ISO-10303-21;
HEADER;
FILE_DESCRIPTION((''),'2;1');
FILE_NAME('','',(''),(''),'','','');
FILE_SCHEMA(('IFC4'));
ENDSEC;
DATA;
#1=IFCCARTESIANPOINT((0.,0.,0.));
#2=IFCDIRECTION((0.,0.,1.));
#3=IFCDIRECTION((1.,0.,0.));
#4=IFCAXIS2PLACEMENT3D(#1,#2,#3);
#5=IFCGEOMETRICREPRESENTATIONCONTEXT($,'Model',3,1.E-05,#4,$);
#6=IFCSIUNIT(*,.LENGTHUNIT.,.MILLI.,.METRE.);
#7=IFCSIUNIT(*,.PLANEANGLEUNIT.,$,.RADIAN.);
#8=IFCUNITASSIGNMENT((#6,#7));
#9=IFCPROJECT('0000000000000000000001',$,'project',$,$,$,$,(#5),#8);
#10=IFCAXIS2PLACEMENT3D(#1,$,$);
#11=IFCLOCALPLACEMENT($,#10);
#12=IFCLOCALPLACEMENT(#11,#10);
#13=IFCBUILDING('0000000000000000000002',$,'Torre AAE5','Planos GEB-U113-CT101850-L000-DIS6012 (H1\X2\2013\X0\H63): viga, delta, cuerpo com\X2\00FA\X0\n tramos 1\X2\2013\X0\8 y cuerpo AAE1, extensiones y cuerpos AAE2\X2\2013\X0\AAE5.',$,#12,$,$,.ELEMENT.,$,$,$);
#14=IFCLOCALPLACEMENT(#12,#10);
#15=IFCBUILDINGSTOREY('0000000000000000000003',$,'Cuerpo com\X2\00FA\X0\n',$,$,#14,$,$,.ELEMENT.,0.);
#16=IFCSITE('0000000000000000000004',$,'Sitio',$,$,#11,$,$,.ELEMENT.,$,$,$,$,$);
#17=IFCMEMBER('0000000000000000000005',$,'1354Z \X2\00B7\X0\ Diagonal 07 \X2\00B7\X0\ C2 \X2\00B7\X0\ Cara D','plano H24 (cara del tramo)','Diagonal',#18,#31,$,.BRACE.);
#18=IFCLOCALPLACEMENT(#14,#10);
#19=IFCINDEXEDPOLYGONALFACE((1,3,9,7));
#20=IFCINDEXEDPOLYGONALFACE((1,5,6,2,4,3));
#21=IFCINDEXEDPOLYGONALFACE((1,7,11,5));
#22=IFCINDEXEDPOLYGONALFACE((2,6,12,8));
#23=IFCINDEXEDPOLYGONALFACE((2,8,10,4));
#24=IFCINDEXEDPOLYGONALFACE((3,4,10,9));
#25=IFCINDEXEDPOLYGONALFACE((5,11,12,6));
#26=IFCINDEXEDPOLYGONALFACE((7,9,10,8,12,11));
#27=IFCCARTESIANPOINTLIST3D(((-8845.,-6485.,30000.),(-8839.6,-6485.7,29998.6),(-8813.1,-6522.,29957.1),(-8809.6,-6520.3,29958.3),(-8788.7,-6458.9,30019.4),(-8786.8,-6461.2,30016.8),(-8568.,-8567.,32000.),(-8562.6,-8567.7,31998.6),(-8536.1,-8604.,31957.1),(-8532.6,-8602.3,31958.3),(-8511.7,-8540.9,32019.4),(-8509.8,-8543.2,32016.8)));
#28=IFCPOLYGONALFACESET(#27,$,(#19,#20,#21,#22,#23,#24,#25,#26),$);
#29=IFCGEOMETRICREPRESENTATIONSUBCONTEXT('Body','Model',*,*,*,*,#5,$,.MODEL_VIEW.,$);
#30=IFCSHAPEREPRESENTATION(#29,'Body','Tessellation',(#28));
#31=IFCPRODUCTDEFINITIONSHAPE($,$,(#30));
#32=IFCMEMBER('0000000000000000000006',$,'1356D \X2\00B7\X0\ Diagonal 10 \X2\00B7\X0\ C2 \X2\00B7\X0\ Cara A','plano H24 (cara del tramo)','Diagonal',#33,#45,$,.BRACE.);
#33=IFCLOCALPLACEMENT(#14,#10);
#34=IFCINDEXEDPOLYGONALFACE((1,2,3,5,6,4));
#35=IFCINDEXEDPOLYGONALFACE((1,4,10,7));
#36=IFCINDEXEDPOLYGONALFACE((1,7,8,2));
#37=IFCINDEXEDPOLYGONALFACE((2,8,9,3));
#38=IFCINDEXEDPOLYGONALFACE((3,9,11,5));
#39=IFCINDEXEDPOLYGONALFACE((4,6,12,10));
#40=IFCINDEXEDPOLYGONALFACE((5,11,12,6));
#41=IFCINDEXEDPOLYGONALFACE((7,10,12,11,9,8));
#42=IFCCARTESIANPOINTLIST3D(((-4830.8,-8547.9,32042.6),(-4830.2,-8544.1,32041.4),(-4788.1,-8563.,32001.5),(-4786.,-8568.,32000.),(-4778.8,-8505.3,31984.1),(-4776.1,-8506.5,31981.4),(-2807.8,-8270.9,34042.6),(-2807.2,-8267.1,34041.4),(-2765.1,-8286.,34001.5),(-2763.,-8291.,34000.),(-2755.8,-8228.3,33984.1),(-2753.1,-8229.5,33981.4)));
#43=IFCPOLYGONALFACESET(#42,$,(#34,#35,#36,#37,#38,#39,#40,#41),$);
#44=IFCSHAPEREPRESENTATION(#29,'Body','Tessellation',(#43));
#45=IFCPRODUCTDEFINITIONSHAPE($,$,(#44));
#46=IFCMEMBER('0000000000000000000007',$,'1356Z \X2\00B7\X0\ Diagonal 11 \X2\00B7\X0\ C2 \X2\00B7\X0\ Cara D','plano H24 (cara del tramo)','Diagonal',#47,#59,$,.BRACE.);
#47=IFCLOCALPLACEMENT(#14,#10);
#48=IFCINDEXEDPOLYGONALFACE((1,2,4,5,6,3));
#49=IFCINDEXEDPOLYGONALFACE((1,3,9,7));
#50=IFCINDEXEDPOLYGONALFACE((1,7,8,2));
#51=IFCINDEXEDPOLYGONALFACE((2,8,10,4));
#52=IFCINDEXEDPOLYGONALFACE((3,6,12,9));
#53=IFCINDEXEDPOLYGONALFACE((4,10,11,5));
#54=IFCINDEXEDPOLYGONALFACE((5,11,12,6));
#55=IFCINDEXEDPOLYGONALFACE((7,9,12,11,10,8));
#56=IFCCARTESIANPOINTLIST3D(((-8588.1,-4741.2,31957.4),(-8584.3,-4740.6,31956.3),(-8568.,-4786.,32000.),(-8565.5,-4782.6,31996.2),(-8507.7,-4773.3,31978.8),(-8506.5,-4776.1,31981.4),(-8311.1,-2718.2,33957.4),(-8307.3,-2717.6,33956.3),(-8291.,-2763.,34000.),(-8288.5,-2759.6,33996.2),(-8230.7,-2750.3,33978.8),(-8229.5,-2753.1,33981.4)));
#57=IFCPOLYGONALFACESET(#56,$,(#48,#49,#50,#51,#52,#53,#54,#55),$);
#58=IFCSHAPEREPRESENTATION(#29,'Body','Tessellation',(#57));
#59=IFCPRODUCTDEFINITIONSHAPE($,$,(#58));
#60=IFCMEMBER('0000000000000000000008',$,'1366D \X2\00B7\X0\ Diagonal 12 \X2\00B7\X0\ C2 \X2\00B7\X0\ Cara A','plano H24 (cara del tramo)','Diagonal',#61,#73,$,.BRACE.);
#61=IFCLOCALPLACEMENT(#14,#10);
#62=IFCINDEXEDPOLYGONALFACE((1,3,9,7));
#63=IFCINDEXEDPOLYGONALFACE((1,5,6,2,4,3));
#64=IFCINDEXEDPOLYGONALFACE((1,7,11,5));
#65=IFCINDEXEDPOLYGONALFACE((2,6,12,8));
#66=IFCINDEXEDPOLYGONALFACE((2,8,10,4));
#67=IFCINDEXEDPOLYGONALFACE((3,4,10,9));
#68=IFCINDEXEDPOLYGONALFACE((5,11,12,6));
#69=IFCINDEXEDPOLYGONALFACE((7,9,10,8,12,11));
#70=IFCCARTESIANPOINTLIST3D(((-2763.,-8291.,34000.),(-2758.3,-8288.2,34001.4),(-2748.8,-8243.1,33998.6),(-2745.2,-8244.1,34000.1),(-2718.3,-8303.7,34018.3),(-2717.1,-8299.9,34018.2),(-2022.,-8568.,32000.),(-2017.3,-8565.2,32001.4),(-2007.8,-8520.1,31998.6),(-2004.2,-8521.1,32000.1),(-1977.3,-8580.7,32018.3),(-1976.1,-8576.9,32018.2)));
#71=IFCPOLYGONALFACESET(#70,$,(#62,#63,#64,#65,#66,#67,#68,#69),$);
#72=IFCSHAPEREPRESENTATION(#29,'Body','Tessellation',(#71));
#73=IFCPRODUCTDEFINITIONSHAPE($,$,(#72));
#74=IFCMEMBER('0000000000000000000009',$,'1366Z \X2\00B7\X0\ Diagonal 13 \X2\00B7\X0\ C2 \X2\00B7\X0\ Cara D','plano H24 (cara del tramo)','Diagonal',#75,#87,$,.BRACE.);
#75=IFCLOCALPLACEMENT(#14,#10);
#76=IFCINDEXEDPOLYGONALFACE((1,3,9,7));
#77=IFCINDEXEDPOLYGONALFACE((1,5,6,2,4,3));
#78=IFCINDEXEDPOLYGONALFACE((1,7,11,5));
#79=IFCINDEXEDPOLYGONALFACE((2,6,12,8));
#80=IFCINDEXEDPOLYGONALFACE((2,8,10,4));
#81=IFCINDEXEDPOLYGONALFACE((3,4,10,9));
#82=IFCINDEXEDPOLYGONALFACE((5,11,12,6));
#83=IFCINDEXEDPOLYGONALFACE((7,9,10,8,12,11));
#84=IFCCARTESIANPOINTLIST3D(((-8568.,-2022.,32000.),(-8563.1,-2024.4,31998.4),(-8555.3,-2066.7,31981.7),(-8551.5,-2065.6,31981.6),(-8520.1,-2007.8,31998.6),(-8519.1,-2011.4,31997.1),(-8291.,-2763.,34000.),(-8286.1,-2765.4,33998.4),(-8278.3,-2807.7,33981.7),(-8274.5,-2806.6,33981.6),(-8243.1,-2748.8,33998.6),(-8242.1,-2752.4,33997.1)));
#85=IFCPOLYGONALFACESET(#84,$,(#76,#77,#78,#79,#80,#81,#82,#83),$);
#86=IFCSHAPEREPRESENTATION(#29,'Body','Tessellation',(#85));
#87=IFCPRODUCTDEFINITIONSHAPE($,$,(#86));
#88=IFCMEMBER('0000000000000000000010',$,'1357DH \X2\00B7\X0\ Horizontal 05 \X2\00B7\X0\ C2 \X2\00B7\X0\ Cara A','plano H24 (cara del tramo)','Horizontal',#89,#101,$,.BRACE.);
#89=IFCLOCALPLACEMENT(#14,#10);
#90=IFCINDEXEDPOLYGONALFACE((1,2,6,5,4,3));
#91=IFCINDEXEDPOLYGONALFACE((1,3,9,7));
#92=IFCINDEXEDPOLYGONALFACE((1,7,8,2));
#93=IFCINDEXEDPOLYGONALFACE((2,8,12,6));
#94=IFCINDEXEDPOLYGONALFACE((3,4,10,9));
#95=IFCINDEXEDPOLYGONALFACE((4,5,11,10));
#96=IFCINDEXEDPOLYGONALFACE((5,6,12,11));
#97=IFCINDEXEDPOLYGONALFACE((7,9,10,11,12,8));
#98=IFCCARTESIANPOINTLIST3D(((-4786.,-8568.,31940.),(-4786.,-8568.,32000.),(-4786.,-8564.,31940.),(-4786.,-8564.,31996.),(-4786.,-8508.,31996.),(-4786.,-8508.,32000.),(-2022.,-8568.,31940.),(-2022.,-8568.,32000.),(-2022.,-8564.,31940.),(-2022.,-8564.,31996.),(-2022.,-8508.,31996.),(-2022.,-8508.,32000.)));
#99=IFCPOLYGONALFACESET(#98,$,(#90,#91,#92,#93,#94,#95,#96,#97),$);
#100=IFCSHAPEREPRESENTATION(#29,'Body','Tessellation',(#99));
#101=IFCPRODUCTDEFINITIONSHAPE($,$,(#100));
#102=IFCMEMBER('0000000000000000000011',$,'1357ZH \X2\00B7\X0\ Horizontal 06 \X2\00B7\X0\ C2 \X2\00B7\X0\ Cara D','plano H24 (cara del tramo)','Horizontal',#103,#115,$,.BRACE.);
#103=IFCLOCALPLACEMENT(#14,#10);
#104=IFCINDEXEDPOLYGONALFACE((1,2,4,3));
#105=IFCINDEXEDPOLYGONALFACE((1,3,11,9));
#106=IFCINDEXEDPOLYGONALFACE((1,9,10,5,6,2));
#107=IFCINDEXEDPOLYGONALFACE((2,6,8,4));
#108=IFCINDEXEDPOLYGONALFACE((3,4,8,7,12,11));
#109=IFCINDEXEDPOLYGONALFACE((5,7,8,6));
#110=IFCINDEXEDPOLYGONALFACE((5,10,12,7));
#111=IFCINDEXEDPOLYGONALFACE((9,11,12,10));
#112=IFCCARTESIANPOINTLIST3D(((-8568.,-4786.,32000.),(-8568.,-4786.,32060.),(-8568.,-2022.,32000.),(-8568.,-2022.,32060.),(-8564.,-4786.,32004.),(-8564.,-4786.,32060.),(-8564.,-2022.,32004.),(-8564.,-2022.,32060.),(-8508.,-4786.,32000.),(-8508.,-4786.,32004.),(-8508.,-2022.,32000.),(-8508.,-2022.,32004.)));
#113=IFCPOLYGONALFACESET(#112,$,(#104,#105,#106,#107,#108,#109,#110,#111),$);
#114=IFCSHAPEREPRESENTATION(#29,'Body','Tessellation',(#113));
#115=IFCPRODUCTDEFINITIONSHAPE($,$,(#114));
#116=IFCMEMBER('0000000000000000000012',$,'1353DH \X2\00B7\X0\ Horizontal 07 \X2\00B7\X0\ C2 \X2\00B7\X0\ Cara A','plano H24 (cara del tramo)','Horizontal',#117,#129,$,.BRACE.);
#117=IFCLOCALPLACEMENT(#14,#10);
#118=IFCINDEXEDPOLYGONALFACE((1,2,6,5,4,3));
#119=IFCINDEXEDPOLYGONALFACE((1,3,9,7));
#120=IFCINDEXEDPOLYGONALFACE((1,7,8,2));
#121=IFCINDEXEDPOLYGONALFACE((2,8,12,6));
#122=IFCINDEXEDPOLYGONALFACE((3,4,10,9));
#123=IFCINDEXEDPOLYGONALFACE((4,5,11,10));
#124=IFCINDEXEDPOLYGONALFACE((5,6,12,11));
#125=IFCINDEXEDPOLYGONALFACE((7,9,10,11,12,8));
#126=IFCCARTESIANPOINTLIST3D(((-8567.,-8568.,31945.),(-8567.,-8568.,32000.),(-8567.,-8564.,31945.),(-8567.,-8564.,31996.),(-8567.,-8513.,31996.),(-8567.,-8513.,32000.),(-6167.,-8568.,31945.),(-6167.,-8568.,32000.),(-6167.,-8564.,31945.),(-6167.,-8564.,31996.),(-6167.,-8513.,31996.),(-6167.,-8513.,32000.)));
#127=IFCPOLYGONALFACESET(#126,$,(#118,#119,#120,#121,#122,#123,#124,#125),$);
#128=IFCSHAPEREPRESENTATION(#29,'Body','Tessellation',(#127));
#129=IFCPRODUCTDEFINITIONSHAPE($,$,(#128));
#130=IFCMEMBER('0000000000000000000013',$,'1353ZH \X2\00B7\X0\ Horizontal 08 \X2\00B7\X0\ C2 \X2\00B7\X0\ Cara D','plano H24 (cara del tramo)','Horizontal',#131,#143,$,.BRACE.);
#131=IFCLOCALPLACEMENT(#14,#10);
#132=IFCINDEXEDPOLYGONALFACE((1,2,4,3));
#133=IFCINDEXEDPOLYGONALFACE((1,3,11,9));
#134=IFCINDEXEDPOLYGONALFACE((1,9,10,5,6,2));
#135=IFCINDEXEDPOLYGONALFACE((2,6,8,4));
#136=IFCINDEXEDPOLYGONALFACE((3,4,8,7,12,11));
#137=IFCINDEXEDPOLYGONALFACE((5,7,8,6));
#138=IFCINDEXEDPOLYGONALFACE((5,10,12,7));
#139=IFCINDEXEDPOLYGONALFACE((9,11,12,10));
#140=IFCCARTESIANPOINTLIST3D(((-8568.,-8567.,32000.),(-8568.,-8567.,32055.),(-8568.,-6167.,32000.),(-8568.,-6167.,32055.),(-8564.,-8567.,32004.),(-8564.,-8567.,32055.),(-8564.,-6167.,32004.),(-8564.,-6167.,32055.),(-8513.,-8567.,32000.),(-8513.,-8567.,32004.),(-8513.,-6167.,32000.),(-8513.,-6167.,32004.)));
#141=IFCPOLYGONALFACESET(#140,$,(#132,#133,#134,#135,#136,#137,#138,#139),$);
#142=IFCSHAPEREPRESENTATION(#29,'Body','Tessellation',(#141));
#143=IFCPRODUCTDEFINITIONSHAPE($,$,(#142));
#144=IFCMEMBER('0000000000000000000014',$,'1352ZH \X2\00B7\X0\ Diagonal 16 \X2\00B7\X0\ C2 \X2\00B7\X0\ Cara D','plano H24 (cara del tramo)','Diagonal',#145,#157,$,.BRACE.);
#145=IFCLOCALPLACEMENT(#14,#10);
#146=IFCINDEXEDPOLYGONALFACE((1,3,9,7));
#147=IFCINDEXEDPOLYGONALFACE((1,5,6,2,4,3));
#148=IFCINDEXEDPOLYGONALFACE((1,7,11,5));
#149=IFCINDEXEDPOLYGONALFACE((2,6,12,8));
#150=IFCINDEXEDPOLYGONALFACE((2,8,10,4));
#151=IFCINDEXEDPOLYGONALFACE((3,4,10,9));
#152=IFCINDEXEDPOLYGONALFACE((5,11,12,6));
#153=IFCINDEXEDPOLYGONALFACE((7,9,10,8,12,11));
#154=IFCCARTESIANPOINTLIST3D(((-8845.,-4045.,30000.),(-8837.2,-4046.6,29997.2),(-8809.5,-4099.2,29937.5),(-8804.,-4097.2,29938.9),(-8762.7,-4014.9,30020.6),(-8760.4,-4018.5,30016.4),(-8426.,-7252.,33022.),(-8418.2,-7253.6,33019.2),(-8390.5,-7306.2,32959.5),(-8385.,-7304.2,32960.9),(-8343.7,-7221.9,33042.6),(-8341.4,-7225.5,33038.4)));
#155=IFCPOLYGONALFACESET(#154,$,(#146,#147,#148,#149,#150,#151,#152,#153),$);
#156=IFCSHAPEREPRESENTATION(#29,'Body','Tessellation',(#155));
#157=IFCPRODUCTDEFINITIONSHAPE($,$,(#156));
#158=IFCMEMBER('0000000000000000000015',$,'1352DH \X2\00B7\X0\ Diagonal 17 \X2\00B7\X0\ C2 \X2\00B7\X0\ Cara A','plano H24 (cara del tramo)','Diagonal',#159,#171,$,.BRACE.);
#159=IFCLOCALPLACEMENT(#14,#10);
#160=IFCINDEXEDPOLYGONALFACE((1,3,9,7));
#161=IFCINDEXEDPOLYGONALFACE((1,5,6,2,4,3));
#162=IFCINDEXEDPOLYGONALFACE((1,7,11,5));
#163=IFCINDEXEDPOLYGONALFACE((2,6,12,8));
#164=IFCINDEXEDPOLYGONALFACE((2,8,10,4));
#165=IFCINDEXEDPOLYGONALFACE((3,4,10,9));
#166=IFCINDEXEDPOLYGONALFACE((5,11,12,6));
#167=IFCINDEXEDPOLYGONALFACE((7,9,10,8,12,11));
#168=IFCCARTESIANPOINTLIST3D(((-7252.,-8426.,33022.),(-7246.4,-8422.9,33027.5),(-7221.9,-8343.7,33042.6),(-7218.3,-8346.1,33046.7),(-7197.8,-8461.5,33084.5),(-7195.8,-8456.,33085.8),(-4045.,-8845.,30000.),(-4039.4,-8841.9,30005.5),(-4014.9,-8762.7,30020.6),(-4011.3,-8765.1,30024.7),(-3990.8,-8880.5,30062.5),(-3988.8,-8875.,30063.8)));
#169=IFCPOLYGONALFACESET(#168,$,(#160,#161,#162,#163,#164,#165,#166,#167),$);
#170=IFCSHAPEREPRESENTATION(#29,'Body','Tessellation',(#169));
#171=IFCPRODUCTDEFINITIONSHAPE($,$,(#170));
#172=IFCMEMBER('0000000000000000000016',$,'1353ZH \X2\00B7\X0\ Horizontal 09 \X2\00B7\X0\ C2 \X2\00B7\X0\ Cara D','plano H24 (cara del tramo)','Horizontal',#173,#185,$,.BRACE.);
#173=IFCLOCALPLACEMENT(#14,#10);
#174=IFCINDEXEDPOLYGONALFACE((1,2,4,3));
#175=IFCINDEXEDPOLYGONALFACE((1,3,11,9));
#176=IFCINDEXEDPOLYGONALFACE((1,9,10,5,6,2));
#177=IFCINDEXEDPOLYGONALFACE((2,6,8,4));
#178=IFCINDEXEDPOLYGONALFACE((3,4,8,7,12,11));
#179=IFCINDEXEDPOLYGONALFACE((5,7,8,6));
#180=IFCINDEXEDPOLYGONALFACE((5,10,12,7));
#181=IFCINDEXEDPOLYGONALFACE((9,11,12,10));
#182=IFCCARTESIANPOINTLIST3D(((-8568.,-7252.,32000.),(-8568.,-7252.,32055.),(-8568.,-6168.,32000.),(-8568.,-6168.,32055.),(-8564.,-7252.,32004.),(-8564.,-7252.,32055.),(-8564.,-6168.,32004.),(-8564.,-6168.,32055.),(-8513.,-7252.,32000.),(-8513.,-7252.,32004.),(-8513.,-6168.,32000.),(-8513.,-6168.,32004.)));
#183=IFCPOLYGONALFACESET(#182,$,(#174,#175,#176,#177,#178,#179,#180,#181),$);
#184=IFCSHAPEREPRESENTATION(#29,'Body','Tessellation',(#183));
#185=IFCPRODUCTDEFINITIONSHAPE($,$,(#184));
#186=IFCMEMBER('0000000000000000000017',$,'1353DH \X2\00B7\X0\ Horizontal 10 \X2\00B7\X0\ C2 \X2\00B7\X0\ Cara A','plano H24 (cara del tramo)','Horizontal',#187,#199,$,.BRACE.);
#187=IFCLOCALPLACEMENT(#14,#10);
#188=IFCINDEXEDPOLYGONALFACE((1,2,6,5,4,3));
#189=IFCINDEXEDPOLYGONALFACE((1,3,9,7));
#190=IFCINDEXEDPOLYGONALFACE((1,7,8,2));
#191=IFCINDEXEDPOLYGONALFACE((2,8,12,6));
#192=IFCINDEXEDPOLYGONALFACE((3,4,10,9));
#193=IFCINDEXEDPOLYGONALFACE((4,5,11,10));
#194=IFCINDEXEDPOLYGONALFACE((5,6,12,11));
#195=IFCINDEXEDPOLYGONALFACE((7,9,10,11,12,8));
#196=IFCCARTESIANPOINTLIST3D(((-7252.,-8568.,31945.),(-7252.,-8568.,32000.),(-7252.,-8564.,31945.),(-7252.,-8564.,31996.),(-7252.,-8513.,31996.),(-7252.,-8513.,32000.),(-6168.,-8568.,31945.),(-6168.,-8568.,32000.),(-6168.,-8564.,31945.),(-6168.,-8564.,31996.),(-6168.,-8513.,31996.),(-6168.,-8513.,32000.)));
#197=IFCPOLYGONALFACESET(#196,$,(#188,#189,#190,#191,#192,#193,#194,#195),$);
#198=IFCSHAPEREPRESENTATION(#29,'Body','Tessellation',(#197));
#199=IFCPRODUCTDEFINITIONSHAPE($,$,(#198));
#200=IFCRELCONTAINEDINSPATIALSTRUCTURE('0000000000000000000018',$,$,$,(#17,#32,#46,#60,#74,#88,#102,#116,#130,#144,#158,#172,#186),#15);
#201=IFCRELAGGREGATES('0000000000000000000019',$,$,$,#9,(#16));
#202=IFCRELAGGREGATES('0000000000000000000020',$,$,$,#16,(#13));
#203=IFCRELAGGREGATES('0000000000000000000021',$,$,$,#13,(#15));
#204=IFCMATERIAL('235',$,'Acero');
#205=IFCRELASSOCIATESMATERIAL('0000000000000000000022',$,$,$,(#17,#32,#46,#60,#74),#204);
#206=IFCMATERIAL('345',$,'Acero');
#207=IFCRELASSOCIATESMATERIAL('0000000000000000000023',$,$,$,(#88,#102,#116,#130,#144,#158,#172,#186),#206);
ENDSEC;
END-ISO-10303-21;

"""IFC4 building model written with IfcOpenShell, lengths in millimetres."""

from ifc_helpers import new_model, si_unit, frame, frame_2d, origin, origin_with_axes, place, context, subcontext, project, spatial, l_section, extrude, material, element, save


model = new_model("IFC4")

# Units and contexts
model_context = context("Model", 3, precision=1e-05, world=origin_with_axes())
body_context = subcontext(model_context, "Body", "Model", "MODEL_VIEW")
ifc_project = project(units=[si_unit("LENGTHUNIT", "METRE", prefix="MILLI"), si_unit("PLANEANGLEUNIT", "RADIAN")], contexts=[model_context])

# Site, building, storey
site_placement = place(None, origin())
site = spatial("IfcSite", under=ifc_project, at=site_placement, Name="Sitio", CompositionType="ELEMENT")
building_placement = place(site_placement, origin())
building = spatial("IfcBuilding", under=site, at=building_placement, Name="Torre AAE5", Description="Planos GEB-U113-CT101850-L000-DIS6012 (H1–H63): viga, delta, cuerpo común tramos 1–8 y cuerpo AAE1, extensiones y cuerpos AAE2–AAE5.", CompositionType="ELEMENT")
storey_placement = place(building_placement, origin())
storey = spatial("IfcBuildingStorey", under=building, at=storey_placement, Name="Cuerpo común", CompositionType="ELEMENT", Elevation=0.0)

# Members
ifc_material_1 = material(Name="235", Category="Acero")
ifc_material_2 = material(Name="345", Category="Acero")
for number, where, z_axis, x_axis, name in (
    (1, (-8568.0, -8567.0, 32000.0), (-0.095509, 0.717869, -0.689596), (0.865687, 0.401881, 0.29846), "1354Z · Diagonal 07 · C2 · Cara D"),
):
    element("IfcMember", number, at=place(storey_placement, frame(where, z_axis=z_axis, x_axis=x_axis)), inside=storey, material=ifc_material_1, Name=name, Description="plano H24 (cara del tramo)", ObjectType="Diagonal", PredefinedType="BRACE", context=body_context, shape_type="SweptSolid", body=[
        extrude(l_section(Depth=65.0, Width=65.0, Thickness=4.0, at=frame_2d((32.5, 32.5))), None, (0.0, 0.0, 1.0), 2900.3),
    ])
for number, where, z_axis, x_axis, name in (
    (2, (-4786.0, -8568.0, 32000.0), (0.70779, 0.096914, 0.699743), (0.152643, 0.946162, -0.285442), "1356D · Diagonal 10 · C2 · Cara A"),
    (3, (-8568.0, -4786.0, 32000.0), (0.096914, 0.70779, 0.699743), (0.946162, 0.152643, -0.285442), "1356Z · Diagonal 11 · C2 · Cara D"),
):
    element("IfcMember", number, at=place(storey_placement, frame(where, z_axis=z_axis, x_axis=x_axis)), inside=storey, material=ifc_material_1, Name=name, Description="plano H24 (cara del tramo)", ObjectType="Diagonal", PredefinedType="BRACE", context=body_context, shape_type="SweptSolid", body=[
        extrude(l_section(Depth=65.0, Width=65.0, Thickness=4.0, at=frame_2d((32.5, 32.5))), None, (0.0, 0.0, 1.0), 2858.2),
    ])
for number, where, z_axis, x_axis, name in (
    (4, (-2763.0, -8291.0, 34000.0), (0.344528, -0.128791, -0.9299), (0.283443, 0.958588, -0.027749), "1366D · Diagonal 12 · C2 · Cara A"),
    (5, (-8291.0, -2763.0, 34000.0), (-0.128791, 0.344528, -0.9299), (0.958588, 0.283443, -0.027749), "1366Z · Diagonal 13 · C2 · Cara D"),
):
    element("IfcMember", number, at=place(storey_placement, frame(where, z_axis=z_axis, x_axis=x_axis)), inside=storey, material=ifc_material_1, Name=name, Description="plano H24 (cara del tramo)", ObjectType="Diagonal", PredefinedType="BRACE", context=body_context, shape_type="SweptSolid", body=[
        extrude(l_section(Depth=50.0, Width=50.0, Thickness=4.0, at=frame_2d((25.0, 25.0))), None, (0.0, 0.0, 1.0), 2150.8),
    ])
for number, where, z_axis, x_axis, name in (
    (6, (-2022.0, -8568.0, 32000.0), (-1.0, 0.0, 0.0), (0.0, 1.0, 0.0), "1357DH · Horizontal 05 · C2 · Cara A"),
    (7, (-8568.0, -2022.0, 32000.0), (0.0, -1.0, 0.0), (1.0, 0.0, 0.0), "1357ZH · Horizontal 06 · C2 · Cara D"),
):
    element("IfcMember", number, at=place(storey_placement, frame(where, z_axis=z_axis, x_axis=x_axis)), inside=storey, material=ifc_material_2, Name=name, Description="plano H24 (cara del tramo)", ObjectType="Horizontal", PredefinedType="BRACE", context=body_context, shape_type="SweptSolid", body=[
        extrude(l_section(Depth=60.0, Width=60.0, Thickness=4.0, at=frame_2d((30.0, 30.0))), None, (0.0, 0.0, 1.0), 2764.0),
    ])
for number, where, z_axis, x_axis, name in (
    (8, (-6167.0, -8568.0, 32000.0), (-1.0, 0.0, 0.0), (0.0, 1.0, 0.0), "1353DH · Horizontal 07 · C2 · Cara A"),
    (9, (-8568.0, -6167.0, 32000.0), (0.0, -1.0, 0.0), (1.0, 0.0, 0.0), "1353ZH · Horizontal 08 · C2 · Cara D"),
):
    element("IfcMember", number, at=place(storey_placement, frame(where, z_axis=z_axis, x_axis=x_axis)), inside=storey, material=ifc_material_2, Name=name, Description="plano H24 (cara del tramo)", ObjectType="Horizontal", PredefinedType="BRACE", context=body_context, shape_type="SweptSolid", body=[
        extrude(l_section(Depth=55.0, Width=55.0, Thickness=4.0, at=frame_2d((27.5, 27.5))), None, (0.0, 0.0, 1.0), 2400.0),
    ])
for number, where, z_axis, x_axis, name in (
    (10, (-8426.0, -7252.0, 33022.0), (-0.09466, 0.724519, -0.682724), (0.91418, 0.334757, 0.228499), "1352ZH · Diagonal 16 · C2 · Cara D"),
    (11, (-7252.0, -8426.0, 33022.0), (0.724519, -0.09466, -0.682724), (0.334757, 0.91418, 0.228499), "1352DH · Diagonal 17 · C2 · Cara A"),
):
    element("IfcMember", number, at=place(storey_placement, frame(where, z_axis=z_axis, x_axis=x_axis)), inside=storey, material=ifc_material_2, Name=name, Description="plano H24 (cara del tramo)", ObjectType="Diagonal", PredefinedType="BRACE", context=body_context, shape_type="SweptSolid", body=[
        extrude(l_section(Depth=90.0, Width=90.0, Thickness=6.0, at=frame_2d((45.0, 45.0))), None, (0.0, 0.0, 1.0), 4426.4),
    ])
for number, where, z_axis, x_axis, name in (
    (12, (-8568.0, -6168.0, 32000.0), (0.0, -1.0, 0.0), (1.0, 0.0, 0.0), "1353ZH · Horizontal 09 · C2 · Cara D"),
    (13, (-6168.0, -8568.0, 32000.0), (-1.0, 0.0, 0.0), (0.0, 1.0, 0.0), "1353DH · Horizontal 10 · C2 · Cara A"),
):
    element("IfcMember", number, at=place(storey_placement, frame(where, z_axis=z_axis, x_axis=x_axis)), inside=storey, material=ifc_material_2, Name=name, Description="plano H24 (cara del tramo)", ObjectType="Horizontal", PredefinedType="BRACE", context=body_context, shape_type="SweptSolid", body=[
        extrude(l_section(Depth=55.0, Width=55.0, Thickness=4.0, at=frame_2d((27.5, 27.5))), None, (0.0, 0.0, 1.0), 1084.0),
    ])

save(model, "model.ifc")
